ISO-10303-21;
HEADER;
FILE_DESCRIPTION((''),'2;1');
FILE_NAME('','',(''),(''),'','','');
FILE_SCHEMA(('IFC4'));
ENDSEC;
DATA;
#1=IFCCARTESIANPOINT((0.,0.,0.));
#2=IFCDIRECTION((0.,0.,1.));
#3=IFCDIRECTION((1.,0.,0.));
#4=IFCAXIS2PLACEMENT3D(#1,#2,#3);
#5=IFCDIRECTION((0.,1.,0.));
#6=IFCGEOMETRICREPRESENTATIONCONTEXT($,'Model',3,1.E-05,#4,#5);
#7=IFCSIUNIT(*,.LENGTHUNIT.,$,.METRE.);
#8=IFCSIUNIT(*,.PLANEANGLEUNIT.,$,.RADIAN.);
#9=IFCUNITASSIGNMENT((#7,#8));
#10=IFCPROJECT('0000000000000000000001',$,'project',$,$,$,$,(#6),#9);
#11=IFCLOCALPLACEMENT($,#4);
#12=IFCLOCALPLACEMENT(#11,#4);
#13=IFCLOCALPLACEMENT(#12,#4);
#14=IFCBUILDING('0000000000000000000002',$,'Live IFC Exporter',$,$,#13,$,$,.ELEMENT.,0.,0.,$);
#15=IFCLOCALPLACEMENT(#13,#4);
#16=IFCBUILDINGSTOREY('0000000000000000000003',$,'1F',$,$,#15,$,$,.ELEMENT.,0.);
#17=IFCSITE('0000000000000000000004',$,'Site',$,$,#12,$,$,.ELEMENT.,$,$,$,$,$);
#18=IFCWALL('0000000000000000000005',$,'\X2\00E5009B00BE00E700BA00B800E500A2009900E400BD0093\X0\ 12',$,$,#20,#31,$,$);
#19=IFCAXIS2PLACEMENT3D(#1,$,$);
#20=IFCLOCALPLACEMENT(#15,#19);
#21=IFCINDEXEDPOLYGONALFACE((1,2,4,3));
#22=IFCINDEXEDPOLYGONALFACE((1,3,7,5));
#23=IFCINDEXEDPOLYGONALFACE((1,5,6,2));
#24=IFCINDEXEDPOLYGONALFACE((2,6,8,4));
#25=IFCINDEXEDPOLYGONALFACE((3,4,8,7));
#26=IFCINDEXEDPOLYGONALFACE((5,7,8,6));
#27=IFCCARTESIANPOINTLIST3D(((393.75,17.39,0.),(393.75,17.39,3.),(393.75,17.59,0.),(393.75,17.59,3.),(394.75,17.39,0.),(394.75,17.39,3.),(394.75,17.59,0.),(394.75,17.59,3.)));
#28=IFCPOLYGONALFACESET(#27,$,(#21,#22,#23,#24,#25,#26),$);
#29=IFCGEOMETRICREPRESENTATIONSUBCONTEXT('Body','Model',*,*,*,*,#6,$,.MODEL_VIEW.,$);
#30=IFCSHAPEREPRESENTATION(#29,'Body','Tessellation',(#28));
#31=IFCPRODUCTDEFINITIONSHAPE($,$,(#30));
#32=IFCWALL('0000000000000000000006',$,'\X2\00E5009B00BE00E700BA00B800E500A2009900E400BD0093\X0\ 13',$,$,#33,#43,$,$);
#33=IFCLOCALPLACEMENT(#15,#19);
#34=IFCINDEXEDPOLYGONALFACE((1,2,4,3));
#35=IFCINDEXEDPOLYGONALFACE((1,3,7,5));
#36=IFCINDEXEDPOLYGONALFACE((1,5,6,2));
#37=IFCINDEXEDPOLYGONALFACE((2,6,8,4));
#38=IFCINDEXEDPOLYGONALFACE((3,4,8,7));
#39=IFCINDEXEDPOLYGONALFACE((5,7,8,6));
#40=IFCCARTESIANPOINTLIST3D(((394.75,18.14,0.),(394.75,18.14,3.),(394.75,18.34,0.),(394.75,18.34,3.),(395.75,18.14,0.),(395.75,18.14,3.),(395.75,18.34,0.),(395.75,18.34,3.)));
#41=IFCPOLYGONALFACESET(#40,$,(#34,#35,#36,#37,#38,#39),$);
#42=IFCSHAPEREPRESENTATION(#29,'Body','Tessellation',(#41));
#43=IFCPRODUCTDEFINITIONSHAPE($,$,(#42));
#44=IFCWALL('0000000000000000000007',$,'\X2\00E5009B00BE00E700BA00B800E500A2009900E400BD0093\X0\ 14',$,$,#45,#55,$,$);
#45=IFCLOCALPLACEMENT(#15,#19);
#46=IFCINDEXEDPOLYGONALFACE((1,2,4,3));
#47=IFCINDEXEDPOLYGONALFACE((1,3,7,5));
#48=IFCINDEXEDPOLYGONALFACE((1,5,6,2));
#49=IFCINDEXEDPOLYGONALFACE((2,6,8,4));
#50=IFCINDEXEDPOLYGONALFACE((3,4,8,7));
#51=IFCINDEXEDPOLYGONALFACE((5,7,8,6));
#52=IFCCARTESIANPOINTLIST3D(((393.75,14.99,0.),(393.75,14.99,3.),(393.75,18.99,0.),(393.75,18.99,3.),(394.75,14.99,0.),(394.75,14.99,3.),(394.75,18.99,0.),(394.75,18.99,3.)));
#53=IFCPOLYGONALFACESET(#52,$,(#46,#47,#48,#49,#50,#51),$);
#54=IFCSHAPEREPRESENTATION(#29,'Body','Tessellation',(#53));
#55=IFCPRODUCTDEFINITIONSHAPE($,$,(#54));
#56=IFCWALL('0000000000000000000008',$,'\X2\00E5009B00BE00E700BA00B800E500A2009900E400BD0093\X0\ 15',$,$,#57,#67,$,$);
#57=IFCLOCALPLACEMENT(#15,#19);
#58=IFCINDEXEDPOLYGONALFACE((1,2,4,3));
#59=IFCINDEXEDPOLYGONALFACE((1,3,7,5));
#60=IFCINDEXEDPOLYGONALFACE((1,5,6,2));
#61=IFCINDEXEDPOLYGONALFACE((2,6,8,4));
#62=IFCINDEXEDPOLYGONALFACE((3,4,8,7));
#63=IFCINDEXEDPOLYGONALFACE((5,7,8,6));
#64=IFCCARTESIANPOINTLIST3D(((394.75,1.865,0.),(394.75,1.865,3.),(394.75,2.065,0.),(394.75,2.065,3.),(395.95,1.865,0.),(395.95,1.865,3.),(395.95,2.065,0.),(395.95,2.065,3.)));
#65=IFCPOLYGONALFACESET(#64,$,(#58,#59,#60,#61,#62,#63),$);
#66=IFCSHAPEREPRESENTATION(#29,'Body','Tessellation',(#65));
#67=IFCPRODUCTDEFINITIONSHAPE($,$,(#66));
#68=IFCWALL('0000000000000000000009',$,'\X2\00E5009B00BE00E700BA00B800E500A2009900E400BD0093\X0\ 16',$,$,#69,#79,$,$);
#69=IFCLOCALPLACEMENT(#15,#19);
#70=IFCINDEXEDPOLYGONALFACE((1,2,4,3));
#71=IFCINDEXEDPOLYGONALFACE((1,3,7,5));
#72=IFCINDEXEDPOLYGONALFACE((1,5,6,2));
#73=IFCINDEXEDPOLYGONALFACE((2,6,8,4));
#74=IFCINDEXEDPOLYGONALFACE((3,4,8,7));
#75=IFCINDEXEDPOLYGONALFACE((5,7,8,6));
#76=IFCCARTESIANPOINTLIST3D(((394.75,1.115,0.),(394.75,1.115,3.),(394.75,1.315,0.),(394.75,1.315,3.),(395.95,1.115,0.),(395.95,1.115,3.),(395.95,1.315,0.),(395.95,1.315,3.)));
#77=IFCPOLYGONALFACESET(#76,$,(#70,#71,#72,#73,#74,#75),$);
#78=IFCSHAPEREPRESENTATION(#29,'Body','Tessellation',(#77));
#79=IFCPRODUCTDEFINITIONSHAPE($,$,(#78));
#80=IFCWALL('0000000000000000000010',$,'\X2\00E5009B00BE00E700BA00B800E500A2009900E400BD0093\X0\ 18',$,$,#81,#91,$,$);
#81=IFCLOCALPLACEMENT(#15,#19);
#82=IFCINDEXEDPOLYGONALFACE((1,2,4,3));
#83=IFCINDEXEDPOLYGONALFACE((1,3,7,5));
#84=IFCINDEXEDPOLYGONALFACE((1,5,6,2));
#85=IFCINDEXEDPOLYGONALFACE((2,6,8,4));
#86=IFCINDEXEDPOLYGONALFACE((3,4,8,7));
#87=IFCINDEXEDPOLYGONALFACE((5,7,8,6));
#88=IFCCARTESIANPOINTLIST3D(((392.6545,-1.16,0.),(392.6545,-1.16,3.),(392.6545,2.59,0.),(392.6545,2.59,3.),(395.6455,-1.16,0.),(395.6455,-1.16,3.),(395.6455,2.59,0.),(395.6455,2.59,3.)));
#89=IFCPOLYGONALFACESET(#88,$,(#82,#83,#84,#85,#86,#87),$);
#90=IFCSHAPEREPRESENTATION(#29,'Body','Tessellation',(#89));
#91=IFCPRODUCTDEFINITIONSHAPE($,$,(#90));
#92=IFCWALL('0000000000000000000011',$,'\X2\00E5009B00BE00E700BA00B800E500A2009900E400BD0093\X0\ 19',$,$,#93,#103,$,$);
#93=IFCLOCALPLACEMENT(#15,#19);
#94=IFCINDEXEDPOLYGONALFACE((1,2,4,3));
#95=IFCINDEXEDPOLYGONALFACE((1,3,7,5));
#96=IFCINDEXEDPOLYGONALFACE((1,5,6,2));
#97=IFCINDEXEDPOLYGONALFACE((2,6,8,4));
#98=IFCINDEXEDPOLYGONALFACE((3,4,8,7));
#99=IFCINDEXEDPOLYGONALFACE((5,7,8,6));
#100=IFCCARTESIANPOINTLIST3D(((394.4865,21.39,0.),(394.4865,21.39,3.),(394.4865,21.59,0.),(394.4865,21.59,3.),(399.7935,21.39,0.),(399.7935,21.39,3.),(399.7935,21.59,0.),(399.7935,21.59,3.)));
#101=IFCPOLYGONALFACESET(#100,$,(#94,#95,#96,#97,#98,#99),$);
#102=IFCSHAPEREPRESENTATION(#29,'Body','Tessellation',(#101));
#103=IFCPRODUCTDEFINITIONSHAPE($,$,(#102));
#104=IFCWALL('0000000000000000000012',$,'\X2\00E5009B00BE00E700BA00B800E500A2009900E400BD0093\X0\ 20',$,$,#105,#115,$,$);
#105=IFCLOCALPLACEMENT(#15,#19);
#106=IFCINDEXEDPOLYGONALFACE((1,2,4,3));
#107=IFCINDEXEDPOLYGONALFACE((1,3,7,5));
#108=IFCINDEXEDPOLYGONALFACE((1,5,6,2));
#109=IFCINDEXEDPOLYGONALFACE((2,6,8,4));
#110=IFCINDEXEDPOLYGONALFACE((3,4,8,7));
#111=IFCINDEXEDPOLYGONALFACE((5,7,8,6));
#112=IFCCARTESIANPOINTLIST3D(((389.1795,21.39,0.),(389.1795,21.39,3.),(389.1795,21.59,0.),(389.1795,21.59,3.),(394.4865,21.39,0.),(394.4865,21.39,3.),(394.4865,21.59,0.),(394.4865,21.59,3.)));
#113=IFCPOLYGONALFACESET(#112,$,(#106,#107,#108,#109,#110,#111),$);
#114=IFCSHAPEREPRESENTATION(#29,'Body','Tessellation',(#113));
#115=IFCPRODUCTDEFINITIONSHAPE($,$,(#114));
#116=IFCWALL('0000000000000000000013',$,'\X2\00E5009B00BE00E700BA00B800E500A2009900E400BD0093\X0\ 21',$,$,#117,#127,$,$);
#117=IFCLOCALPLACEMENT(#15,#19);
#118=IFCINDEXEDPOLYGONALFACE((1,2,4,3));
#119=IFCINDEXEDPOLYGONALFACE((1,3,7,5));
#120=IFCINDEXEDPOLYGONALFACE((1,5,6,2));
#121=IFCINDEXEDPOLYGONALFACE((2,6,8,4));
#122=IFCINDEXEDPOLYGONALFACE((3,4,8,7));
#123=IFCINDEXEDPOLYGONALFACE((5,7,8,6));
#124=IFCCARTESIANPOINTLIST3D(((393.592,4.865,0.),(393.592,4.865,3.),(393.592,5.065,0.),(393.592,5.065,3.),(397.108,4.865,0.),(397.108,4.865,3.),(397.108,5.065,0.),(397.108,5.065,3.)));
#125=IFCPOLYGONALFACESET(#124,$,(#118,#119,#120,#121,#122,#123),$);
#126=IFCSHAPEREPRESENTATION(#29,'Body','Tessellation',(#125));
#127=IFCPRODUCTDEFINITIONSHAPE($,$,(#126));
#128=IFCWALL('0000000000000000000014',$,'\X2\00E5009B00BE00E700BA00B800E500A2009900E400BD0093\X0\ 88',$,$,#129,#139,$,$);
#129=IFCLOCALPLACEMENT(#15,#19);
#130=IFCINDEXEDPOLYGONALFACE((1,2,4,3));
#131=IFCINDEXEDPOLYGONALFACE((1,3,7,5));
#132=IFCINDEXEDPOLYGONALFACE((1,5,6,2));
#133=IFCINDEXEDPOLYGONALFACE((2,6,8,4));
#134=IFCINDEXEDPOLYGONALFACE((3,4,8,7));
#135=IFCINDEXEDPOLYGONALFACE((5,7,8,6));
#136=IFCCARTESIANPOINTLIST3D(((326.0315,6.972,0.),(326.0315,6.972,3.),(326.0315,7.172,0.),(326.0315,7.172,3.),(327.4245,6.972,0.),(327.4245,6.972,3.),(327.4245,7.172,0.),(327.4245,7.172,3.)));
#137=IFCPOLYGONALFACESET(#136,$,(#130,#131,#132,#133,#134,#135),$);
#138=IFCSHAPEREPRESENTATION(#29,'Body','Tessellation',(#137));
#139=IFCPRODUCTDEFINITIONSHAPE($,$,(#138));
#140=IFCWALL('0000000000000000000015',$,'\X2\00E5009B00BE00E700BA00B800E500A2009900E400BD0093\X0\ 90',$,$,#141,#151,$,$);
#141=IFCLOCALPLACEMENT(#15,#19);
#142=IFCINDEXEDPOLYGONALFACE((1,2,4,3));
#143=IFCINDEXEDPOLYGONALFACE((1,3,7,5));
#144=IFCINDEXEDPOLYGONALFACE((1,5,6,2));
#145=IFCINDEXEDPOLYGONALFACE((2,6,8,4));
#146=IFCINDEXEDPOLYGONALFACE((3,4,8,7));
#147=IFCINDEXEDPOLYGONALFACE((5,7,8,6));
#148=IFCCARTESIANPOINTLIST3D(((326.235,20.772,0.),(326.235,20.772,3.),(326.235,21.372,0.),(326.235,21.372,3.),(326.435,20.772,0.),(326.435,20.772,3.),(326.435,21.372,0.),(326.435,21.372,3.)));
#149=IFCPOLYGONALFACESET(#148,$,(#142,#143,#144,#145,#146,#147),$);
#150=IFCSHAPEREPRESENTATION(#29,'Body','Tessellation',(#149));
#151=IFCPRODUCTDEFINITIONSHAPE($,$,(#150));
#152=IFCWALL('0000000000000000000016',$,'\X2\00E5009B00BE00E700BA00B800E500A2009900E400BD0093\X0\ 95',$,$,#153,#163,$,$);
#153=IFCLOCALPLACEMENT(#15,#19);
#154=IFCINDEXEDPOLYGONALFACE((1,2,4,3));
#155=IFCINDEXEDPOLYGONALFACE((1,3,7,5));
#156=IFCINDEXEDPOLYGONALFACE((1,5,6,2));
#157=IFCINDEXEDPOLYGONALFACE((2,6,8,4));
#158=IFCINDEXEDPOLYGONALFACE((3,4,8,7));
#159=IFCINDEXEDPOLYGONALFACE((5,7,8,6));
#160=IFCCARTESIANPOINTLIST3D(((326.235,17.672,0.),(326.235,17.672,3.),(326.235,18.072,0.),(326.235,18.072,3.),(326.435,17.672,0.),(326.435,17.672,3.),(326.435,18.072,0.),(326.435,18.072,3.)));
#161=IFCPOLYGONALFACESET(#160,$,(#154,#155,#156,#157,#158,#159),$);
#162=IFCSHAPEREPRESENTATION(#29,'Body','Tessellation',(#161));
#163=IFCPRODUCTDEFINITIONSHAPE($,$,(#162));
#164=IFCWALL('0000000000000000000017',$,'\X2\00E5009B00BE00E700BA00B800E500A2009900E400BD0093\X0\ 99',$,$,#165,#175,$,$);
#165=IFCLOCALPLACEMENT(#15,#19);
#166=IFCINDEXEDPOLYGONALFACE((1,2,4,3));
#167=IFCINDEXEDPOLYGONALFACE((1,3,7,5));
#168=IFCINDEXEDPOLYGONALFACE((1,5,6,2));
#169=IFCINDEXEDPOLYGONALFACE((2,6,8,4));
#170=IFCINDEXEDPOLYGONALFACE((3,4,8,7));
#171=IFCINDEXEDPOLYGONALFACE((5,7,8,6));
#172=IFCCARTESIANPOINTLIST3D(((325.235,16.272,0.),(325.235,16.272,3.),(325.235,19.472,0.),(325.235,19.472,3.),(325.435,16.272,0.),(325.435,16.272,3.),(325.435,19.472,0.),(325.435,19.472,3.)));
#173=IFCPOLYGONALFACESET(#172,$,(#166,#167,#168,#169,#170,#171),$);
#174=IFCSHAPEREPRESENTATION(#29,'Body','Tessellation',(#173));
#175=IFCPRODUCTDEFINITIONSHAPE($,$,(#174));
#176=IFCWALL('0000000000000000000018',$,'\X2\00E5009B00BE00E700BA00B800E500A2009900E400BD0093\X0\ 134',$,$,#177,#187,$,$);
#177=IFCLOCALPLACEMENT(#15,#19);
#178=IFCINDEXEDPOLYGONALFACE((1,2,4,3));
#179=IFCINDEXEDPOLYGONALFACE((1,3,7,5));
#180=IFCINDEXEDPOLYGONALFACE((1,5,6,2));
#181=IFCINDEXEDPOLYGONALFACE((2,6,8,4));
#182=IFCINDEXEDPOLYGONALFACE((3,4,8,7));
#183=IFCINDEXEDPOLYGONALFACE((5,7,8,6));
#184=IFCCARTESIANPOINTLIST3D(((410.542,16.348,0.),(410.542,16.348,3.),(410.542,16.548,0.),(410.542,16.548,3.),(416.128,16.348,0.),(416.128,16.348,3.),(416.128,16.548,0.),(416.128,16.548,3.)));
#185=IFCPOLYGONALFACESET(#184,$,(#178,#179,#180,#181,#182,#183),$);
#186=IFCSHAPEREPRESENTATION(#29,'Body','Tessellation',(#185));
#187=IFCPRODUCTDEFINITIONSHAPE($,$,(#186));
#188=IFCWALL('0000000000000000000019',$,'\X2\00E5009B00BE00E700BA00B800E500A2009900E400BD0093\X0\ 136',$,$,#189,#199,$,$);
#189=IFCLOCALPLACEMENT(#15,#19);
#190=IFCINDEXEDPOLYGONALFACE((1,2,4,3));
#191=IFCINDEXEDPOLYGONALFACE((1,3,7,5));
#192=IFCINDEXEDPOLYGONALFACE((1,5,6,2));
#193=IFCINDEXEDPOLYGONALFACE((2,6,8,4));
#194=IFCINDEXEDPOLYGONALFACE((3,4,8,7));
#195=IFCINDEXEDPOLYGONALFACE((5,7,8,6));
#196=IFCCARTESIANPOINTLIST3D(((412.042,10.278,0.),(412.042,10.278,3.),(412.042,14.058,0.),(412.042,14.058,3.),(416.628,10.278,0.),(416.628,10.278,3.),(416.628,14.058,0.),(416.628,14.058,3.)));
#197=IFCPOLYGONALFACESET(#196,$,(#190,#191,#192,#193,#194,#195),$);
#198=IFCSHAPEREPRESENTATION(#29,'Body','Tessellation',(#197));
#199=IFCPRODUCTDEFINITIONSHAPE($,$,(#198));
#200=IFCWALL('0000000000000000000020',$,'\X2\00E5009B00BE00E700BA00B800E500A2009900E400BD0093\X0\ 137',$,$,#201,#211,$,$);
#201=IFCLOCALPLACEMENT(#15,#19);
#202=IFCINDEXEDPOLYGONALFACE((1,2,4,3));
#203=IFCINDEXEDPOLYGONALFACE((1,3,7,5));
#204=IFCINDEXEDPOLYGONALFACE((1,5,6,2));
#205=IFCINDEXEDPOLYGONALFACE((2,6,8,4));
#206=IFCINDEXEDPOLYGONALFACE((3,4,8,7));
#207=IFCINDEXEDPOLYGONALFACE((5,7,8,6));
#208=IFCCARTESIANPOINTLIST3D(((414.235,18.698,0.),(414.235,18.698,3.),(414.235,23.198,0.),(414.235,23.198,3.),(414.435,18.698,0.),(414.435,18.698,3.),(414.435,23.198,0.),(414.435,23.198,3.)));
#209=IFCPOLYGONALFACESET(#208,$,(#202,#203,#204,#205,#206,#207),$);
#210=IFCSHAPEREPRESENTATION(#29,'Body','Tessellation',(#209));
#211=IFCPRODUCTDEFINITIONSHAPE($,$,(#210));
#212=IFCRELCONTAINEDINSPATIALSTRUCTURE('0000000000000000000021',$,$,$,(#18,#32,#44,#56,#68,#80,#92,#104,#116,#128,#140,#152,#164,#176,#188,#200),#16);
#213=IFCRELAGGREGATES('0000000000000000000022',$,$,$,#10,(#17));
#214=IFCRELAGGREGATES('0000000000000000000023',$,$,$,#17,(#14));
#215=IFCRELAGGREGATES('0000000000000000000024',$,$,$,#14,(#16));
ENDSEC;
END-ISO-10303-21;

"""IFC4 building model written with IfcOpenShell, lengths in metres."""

from ifc_helpers import new_model, si_unit, direction, frame, frame_2d, origin_with_axes, place, context, subcontext, project, spatial, rectangle, extrude, element, save


model = new_model("IFC4")

# Units and contexts
model_context = context("Model", 3, precision=1e-05, world=origin_with_axes(), true_north=direction((0.0, 1.0, 0.0)))
body_context = subcontext(model_context, "Body", "Model", "MODEL_VIEW")
ifc_project = project(units=[si_unit("LENGTHUNIT", "METRE"), si_unit("PLANEANGLEUNIT", "RADIAN")], contexts=[model_context])

# Site, building, storey
placement = place(None, origin_with_axes())
site_placement = place(placement, origin_with_axes())
site = spatial("IfcSite", under=ifc_project, at=site_placement, Name="Site", CompositionType="ELEMENT")
building_placement = place(site_placement, origin_with_axes())
building = spatial("IfcBuilding", under=site, at=building_placement, Name="Live IFC Exporter", CompositionType="ELEMENT", ElevationOfRefHeight=0.0, ElevationOfTerrain=0.0)
storey_placement = place(building_placement, origin_with_axes())
storey = spatial("IfcBuildingStorey", under=building, at=storey_placement, Name="1F", CompositionType="ELEMENT", Elevation=0.0)

# Walls
for number, where, z_axis, x_axis, name in (
    (1, (394.25, 17.49, 0.0), (0.0, 0.0, 1.0), (1.0, 0.0, 0.0), "å\u009b¾çº¸å¢\u0099ä½\u0093 12"),
    (2, (395.25, 18.24, 0.0), (0.0, 0.0, 1.0), (-1.0, 0.0, 0.0), "å\u009b¾çº¸å¢\u0099ä½\u0093 13"),
):
    element("IfcWall", number, at=place(storey_placement, frame(where, z_axis=z_axis, x_axis=x_axis)), inside=storey, Name=name, context=body_context, shape_type="SweptSolid", body=[
        extrude(rectangle(XDim=1.0, YDim=0.2, at=frame_2d((0.0, 0.0), x_axis=(1.0, 0.0, 0.0))), frame((0.0, 0.0, 0.0), z_axis=(0.0, 0.0, 1.0)), (0.0, 0.0, 1.0), 3.0),
    ])
wall_1_placement = place(storey_placement, frame((394.25, 16.99, 0.0), z_axis=(0.0, 0.0, 1.0), x_axis=(1.0, 0.0, 0.0)))
element("IfcWall", 3, at=wall_1_placement, inside=storey, Name="å\u009b¾çº¸å¢\u0099ä½\u0093 14", context=body_context, shape_type="SweptSolid", body=[
    extrude(rectangle(XDim=1.0, YDim=4.0, at=frame_2d((0.0, 0.0), x_axis=(1.0, 0.0, 0.0))), frame((0.0, 0.0, 0.0), z_axis=(0.0, 0.0, 1.0)), (0.0, 0.0, 1.0), 3.0),
])
for number, where, z_axis, x_axis, name in (
    (4, (395.35, 1.965, 0.0), (0.0, 0.0, 1.0), (-1.0, 0.0, 0.0), "å\u009b¾çº¸å¢\u0099ä½\u0093 15"),
    (5, (395.35, 1.215, 0.0), (0.0, 0.0, 1.0), (-1.0, 0.0, 0.0), "å\u009b¾çº¸å¢\u0099ä½\u0093 16"),
):
    element("IfcWall", number, at=place(storey_placement, frame(where, z_axis=z_axis, x_axis=x_axis)), inside=storey, Name=name, context=body_context, shape_type="SweptSolid", body=[
        extrude(rectangle(XDim=1.2, YDim=0.2, at=frame_2d((0.0, 0.0), x_axis=(1.0, 0.0, 0.0))), frame((0.0, 0.0, 0.0), z_axis=(0.0, 0.0, 1.0)), (0.0, 0.0, 1.0), 3.0),
    ])
wall_2_placement = place(storey_placement, frame((394.15, 0.715, 0.0), z_axis=(0.0, 0.0, 1.0), x_axis=(1.0, 0.0, 0.0)))
element("IfcWall", 6, at=wall_2_placement, inside=storey, Name="å\u009b¾çº¸å¢\u0099ä½\u0093 18", context=body_context, shape_type="SweptSolid", body=[
    extrude(rectangle(XDim=2.991, YDim=3.75, at=frame_2d((0.0, 0.0), x_axis=(1.0, 0.0, 0.0))), frame((0.0, 0.0, 0.0), z_axis=(0.0, 0.0, 1.0)), (0.0, 0.0, 1.0), 3.0),
])
for number, where, z_axis, x_axis, name in (
    (7, (397.14, 21.49, 0.0), (0.0, 0.0, 1.0), (-1.0, 0.0, 0.0), "å\u009b¾çº¸å¢\u0099ä½\u0093 19"),
    (8, (391.833, 21.49, 0.0), (0.0, 0.0, 1.0), (1.0, 0.0, 0.0), "å\u009b¾çº¸å¢\u0099ä½\u0093 20"),
):
    element("IfcWall", number, at=place(storey_placement, frame(where, z_axis=z_axis, x_axis=x_axis)), inside=storey, Name=name, context=body_context, shape_type="SweptSolid", body=[
        extrude(rectangle(XDim=5.307, YDim=0.2, at=frame_2d((0.0, 0.0), x_axis=(1.0, 0.0, 0.0))), frame((0.0, 0.0, 0.0), z_axis=(0.0, 0.0, 1.0)), (0.0, 0.0, 1.0), 3.0),
    ])
wall_3_placement = place(storey_placement, frame((395.35, 4.965, 0.0), z_axis=(0.0, 0.0, 1.0), x_axis=(-1.0, 0.0, 0.0)))
element("IfcWall", 9, at=wall_3_placement, inside=storey, Name="å\u009b¾çº¸å¢\u0099ä½\u0093 21", context=body_context, shape_type="SweptSolid", body=[
    extrude(rectangle(XDim=3.516, YDim=0.2, at=frame_2d((0.0, 0.0), x_axis=(1.0, 0.0, 0.0))), frame((0.0, 0.0, 0.0), z_axis=(0.0, 0.0, 1.0)), (0.0, 0.0, 1.0), 3.0),
])
wall_4_placement = place(storey_placement, frame((326.728, 7.072, 0.0), z_axis=(0.0, 0.0, 1.0), x_axis=(-1.0, 0.0, 0.0)))
element("IfcWall", 10, at=wall_4_placement, inside=storey, Name="å\u009b¾çº¸å¢\u0099ä½\u0093 88", context=body_context, shape_type="SweptSolid", body=[
    extrude(rectangle(XDim=1.393, YDim=0.2, at=frame_2d((0.0, 0.0), x_axis=(1.0, 0.0, 0.0))), frame((0.0, 0.0, 0.0), z_axis=(0.0, 0.0, 1.0)), (0.0, 0.0, 1.0), 3.0),
])
wall_5_placement = place(storey_placement, frame((326.335, 21.072, 0.0), z_axis=(0.0, 0.0, 1.0), x_axis=(0.0, 1.0, 0.0)))
element("IfcWall", 11, at=wall_5_placement, inside=storey, Name="å\u009b¾çº¸å¢\u0099ä½\u0093 90", context=body_context, shape_type="SweptSolid", body=[
    extrude(rectangle(XDim=0.6, YDim=0.2, at=frame_2d((0.0, 0.0), x_axis=(1.0, 0.0, 0.0))), frame((0.0, 0.0, 0.0), z_axis=(0.0, 0.0, 1.0)), (0.0, 0.0, 1.0), 3.0),
])
wall_6_placement = place(storey_placement, frame((326.335, 17.872, 0.0), z_axis=(0.0, 0.0, 1.0), x_axis=(0.0, -1.0, 0.0)))
element("IfcWall", 12, at=wall_6_placement, inside=storey, Name="å\u009b¾çº¸å¢\u0099ä½\u0093 95", context=body_context, shape_type="SweptSolid", body=[
    extrude(rectangle(XDim=0.4, YDim=0.2, at=frame_2d((0.0, 0.0), x_axis=(1.0, 0.0, 0.0))), frame((0.0, 0.0, 0.0), z_axis=(0.0, 0.0, 1.0)), (0.0, 0.0, 1.0), 3.0),
])
wall_7_placement = place(storey_placement, frame((325.335, 17.872, 0.0), z_axis=(0.0, 0.0, 1.0), x_axis=(0.0, 1.0, 0.0)))
element("IfcWall", 13, at=wall_7_placement, inside=storey, Name="å\u009b¾çº¸å¢\u0099ä½\u0093 99", context=body_context, shape_type="SweptSolid", body=[
    extrude(rectangle(XDim=3.2, YDim=0.2, at=frame_2d((0.0, 0.0), x_axis=(1.0, 0.0, 0.0))), frame((0.0, 0.0, 0.0), z_axis=(0.0, 0.0, 1.0)), (0.0, 0.0, 1.0), 3.0),
])
wall_8_placement = place(storey_placement, frame((413.335, 16.448, 0.0), z_axis=(0.0, 0.0, 1.0), x_axis=(1.0, 0.0, 0.0)))
element("IfcWall", 14, at=wall_8_placement, inside=storey, Name="å\u009b¾çº¸å¢\u0099ä½\u0093 134", context=body_context, shape_type="SweptSolid", body=[
    extrude(rectangle(XDim=5.586, YDim=0.2, at=frame_2d((0.0, 0.0), x_axis=(1.0, 0.0, 0.0))), frame((0.0, 0.0, 0.0), z_axis=(0.0, 0.0, 1.0)), (0.0, 0.0, 1.0), 3.0),
])
wall_9_placement = place(storey_placement, frame((414.335, 12.168, 0.0), z_axis=(0.0, 0.0, 1.0), x_axis=(1.0, 0.0, 0.0)))
element("IfcWall", 15, at=wall_9_placement, inside=storey, Name="å\u009b¾çº¸å¢\u0099ä½\u0093 136", context=body_context, shape_type="SweptSolid", body=[
    extrude(rectangle(XDim=4.586, YDim=3.78, at=frame_2d((0.0, 0.0), x_axis=(1.0, 0.0, 0.0))), frame((0.0, 0.0, 0.0), z_axis=(0.0, 0.0, 1.0)), (0.0, 0.0, 1.0), 3.0),
])
wall_10_placement = place(storey_placement, frame((414.335, 20.948, 0.0), z_axis=(0.0, 0.0, 1.0), x_axis=(0.0, -1.0, 0.0)))
element("IfcWall", 16, at=wall_10_placement, inside=storey, Name="å\u009b¾çº¸å¢\u0099ä½\u0093 137", context=body_context, shape_type="SweptSolid", body=[
    extrude(rectangle(XDim=4.5, YDim=0.2, at=frame_2d((0.0, 0.0), x_axis=(1.0, 0.0, 0.0))), frame((0.0, 0.0, 0.0), z_axis=(0.0, 0.0, 1.0)), (0.0, 0.0, 1.0), 3.0),
])

save(model, "model.ifc")
